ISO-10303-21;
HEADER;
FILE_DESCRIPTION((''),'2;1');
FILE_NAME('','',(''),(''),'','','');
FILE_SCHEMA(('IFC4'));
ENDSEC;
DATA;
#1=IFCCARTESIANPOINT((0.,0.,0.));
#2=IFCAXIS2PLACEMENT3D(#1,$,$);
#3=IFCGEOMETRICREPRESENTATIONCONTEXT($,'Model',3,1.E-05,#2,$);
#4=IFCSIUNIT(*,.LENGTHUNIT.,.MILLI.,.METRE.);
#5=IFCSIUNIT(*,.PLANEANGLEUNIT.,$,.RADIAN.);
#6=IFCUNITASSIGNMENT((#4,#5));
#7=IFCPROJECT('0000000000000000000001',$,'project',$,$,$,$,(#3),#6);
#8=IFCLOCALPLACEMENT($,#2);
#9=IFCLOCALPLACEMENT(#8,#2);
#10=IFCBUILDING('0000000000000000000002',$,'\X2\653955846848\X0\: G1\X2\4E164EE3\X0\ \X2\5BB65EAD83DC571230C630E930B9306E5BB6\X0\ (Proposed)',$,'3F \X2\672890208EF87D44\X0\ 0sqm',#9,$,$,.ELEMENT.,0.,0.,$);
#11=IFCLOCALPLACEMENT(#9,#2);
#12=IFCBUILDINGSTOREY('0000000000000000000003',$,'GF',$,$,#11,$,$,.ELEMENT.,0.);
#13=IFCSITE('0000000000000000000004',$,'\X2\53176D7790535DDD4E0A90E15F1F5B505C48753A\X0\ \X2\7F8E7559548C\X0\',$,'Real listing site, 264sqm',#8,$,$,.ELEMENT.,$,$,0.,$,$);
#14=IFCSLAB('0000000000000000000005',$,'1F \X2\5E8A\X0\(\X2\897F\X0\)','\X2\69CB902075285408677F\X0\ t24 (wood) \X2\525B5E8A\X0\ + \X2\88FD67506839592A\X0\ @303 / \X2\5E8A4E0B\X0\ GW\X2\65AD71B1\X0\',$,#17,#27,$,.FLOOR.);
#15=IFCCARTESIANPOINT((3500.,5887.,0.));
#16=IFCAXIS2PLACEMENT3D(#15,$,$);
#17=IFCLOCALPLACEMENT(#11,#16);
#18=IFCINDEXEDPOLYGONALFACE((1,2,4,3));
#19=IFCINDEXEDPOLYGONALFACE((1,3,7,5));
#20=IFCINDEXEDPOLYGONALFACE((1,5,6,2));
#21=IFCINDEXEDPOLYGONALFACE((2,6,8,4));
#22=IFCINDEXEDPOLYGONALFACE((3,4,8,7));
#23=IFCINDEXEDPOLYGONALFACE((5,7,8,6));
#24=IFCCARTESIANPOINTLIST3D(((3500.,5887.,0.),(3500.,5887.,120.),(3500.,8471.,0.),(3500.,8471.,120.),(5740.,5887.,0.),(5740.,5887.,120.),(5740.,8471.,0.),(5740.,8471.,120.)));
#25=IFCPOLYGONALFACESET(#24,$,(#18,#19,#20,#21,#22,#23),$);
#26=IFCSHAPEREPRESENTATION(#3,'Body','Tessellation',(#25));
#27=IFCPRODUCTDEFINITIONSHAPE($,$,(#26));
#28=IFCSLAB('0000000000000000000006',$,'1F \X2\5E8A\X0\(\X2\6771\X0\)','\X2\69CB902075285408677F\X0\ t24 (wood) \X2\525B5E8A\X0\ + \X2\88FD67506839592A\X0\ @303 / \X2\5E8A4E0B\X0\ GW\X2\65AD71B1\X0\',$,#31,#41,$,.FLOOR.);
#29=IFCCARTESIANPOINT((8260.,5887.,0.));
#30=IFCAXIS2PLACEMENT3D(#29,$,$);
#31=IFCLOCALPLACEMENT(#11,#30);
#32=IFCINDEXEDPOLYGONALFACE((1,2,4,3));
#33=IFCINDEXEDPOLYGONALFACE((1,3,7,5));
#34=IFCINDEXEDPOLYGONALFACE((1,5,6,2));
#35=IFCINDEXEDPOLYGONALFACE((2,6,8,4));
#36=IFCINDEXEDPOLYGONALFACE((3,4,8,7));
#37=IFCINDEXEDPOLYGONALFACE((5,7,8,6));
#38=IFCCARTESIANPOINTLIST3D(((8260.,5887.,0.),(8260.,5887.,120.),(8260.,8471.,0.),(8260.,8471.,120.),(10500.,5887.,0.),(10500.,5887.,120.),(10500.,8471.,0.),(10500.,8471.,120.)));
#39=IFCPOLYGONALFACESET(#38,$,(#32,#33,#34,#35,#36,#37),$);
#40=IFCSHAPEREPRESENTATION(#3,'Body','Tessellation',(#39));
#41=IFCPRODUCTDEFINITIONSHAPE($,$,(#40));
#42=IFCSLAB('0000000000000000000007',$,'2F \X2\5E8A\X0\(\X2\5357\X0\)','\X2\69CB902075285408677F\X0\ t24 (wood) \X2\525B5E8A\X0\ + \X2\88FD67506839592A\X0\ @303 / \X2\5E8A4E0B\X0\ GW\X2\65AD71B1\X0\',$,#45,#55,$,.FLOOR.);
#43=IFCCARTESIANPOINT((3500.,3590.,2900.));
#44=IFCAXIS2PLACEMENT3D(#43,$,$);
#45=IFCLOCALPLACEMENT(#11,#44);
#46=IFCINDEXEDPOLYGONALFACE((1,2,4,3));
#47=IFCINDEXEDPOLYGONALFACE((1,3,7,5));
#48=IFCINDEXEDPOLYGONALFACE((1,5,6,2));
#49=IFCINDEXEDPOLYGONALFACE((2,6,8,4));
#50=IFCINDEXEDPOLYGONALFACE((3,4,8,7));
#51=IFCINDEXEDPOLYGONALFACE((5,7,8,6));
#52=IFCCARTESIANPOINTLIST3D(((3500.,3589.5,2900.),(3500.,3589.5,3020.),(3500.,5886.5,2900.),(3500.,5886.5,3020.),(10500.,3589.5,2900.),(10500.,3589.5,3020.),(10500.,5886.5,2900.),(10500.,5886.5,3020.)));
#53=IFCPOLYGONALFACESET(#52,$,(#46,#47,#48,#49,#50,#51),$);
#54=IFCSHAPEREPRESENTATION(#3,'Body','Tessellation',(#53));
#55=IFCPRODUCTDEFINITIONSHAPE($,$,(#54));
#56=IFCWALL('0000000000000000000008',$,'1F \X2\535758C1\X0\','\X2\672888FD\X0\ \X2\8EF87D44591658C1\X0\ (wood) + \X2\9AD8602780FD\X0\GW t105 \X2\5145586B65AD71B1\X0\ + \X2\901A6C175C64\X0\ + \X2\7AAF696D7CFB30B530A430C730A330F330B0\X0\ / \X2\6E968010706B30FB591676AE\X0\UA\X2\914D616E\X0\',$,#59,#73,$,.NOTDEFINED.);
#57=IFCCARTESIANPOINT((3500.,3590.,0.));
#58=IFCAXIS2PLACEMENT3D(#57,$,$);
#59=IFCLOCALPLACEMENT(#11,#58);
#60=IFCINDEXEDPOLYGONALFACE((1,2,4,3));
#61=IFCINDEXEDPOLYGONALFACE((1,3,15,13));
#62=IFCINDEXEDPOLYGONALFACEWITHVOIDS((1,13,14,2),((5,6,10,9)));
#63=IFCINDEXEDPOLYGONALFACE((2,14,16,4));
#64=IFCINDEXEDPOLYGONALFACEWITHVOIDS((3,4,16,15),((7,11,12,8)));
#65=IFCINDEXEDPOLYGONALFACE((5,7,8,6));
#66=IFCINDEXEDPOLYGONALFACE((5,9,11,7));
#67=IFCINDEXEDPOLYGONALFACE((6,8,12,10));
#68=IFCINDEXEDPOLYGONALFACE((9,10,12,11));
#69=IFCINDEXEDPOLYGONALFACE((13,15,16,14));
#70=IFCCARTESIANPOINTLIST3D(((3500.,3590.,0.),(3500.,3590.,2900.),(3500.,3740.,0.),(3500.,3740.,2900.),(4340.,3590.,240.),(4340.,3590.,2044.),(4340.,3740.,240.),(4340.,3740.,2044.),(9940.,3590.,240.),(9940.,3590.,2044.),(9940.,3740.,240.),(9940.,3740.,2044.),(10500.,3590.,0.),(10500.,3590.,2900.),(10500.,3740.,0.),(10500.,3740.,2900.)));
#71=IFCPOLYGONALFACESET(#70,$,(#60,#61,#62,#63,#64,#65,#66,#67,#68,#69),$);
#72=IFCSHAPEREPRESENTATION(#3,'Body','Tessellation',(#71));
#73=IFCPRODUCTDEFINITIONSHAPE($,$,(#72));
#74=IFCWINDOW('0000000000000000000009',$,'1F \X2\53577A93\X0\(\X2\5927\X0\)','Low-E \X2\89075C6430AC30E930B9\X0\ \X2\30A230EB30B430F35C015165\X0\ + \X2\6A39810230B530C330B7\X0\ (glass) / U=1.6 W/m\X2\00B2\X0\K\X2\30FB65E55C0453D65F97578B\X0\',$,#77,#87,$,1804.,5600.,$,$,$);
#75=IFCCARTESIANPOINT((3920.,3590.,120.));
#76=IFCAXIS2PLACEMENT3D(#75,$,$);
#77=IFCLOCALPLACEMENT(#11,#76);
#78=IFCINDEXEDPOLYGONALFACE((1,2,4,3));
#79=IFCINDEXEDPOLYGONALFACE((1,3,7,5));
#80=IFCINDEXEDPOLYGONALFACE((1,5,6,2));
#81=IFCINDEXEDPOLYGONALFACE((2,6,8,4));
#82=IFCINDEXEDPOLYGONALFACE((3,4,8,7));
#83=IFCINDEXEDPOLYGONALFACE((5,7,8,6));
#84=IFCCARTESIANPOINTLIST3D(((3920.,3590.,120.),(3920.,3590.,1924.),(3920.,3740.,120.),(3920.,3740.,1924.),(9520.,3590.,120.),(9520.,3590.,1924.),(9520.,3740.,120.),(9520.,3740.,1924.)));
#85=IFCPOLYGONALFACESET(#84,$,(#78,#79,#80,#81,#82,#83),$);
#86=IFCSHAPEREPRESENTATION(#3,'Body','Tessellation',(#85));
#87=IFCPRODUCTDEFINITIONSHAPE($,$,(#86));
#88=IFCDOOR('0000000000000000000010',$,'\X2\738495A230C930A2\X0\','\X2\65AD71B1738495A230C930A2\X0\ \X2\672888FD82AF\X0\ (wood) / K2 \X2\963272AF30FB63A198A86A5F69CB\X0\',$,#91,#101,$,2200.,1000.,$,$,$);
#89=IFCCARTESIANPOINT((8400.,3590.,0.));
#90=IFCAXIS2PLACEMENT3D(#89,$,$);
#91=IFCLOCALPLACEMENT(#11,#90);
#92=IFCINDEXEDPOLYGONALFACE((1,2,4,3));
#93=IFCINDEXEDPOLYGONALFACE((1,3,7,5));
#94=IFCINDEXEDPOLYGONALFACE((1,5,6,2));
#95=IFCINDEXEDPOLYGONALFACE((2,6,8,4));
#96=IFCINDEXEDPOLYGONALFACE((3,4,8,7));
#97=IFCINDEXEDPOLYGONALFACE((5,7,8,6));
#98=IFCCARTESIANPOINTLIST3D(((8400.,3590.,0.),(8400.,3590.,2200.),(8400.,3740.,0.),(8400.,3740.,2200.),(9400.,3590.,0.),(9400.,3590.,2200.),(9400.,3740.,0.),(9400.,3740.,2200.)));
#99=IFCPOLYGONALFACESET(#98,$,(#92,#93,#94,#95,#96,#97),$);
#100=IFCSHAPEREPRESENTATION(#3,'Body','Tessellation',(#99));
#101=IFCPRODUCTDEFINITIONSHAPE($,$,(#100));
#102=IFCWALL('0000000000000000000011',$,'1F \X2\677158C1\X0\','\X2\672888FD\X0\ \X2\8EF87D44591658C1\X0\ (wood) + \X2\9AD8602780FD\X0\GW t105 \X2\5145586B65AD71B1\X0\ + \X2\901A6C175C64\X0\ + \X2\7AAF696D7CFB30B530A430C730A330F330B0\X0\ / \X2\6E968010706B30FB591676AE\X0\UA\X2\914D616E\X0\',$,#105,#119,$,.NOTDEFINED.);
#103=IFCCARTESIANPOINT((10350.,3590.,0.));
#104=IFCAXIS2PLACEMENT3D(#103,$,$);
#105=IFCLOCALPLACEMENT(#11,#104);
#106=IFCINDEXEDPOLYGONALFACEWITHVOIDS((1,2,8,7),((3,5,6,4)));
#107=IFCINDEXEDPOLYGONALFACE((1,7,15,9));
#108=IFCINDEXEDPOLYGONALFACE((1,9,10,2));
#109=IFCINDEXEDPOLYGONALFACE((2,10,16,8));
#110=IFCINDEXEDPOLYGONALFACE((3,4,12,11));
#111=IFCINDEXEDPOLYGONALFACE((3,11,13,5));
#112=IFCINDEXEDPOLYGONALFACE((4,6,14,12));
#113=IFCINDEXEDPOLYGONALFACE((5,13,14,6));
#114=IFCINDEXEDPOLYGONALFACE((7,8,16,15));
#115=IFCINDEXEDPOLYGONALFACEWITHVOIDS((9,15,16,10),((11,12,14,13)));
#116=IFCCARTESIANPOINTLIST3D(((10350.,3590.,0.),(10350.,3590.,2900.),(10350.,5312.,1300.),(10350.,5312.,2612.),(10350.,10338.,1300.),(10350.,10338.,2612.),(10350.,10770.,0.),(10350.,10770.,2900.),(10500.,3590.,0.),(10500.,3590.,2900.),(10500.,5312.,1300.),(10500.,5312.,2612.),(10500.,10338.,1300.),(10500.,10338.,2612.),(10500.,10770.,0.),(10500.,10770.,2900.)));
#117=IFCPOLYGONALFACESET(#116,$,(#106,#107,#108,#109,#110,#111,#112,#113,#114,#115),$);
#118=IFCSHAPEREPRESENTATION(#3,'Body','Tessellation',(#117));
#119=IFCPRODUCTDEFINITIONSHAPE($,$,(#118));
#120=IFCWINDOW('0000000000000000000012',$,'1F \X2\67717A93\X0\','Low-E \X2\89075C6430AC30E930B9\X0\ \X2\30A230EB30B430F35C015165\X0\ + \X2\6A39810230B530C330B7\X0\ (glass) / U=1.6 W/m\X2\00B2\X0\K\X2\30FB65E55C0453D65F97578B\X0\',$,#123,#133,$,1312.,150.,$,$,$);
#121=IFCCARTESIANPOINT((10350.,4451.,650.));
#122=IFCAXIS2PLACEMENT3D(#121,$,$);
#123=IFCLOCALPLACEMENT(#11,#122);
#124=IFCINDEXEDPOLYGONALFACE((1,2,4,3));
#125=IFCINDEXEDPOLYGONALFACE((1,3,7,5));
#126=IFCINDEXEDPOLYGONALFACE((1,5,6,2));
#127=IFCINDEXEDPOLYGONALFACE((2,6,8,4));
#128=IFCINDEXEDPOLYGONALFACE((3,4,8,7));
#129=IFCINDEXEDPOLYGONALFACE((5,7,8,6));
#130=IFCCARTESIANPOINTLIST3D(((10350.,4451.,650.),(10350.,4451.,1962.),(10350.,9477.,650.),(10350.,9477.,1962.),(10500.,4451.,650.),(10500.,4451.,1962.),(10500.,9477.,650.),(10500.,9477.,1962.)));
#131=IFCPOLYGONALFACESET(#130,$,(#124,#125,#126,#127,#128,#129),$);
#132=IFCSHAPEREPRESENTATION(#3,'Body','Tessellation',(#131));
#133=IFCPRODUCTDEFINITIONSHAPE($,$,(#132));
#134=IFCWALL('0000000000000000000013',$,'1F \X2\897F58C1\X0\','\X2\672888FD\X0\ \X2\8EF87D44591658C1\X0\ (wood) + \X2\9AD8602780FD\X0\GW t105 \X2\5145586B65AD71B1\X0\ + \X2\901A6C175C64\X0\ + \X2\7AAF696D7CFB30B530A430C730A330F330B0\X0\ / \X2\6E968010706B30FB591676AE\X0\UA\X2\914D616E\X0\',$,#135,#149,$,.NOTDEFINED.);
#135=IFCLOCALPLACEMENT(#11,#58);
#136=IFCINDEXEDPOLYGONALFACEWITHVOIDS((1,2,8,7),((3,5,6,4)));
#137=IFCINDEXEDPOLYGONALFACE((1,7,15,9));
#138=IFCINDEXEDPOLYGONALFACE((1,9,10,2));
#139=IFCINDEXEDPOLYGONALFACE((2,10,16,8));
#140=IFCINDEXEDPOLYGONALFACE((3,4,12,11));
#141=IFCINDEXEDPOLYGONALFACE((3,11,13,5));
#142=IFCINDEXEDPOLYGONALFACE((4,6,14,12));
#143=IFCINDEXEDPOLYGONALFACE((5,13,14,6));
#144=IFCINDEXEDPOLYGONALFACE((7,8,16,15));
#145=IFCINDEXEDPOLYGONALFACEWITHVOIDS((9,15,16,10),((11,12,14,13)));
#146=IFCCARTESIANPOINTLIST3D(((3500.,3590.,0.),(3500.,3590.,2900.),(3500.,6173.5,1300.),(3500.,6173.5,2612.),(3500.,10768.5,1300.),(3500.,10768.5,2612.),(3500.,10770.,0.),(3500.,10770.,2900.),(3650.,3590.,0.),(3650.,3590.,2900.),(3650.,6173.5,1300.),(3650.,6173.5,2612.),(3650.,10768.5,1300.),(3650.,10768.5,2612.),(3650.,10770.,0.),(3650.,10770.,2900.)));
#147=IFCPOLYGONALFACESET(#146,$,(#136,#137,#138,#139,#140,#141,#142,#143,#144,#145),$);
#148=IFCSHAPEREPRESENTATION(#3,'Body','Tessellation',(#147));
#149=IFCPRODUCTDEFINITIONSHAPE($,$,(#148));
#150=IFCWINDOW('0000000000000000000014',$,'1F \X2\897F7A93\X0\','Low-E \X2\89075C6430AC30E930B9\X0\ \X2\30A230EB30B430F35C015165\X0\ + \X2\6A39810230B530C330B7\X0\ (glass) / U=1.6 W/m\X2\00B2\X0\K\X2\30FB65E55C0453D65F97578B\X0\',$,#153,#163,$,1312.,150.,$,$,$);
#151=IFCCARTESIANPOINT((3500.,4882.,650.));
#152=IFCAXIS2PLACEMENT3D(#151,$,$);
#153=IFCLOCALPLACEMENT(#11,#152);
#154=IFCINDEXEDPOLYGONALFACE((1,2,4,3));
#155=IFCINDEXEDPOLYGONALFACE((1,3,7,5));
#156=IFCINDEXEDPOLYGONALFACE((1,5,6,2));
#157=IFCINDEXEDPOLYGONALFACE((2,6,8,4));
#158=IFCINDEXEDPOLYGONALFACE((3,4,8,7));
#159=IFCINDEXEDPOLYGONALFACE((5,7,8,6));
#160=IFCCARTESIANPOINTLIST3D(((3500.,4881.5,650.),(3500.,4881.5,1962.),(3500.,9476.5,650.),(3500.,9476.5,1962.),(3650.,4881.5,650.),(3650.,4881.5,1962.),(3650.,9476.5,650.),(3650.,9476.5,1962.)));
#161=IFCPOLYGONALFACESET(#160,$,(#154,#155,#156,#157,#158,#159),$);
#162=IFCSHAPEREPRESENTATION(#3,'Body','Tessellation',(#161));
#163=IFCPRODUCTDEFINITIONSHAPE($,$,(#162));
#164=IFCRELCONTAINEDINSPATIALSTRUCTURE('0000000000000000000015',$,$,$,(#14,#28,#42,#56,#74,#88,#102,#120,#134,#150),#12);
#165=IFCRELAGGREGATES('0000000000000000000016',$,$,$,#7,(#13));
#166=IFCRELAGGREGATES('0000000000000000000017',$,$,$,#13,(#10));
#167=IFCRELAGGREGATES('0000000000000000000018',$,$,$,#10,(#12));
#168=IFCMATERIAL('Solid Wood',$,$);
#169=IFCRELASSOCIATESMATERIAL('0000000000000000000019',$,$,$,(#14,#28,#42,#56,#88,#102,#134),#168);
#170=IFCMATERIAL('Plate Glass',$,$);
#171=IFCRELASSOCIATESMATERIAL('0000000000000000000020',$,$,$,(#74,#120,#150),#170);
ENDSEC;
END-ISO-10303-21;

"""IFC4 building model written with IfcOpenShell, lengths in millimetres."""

from ifc_helpers import new_model, si_unit, frame, frame_2d, origin, place, context, project, spatial, rectangle, extrude, material, element, fill, save


model = new_model("IFC4")

# Units and contexts
model_context = context("Model", 3, precision=1e-05, world=origin())
ifc_project = project(units=[si_unit("LENGTHUNIT", "METRE", prefix="MILLI"), si_unit("PLANEANGLEUNIT", "RADIAN")], contexts=[model_context])

# Site, building, storey
site_placement = place(None, origin())
site = spatial("IfcSite", under=ifc_project, at=site_placement, Name="北海道川上郡弟子屈町 美留和", ObjectType="Real listing site, 264sqm", CompositionType="ELEMENT", RefElevation=0.0)
building_placement = place(site_placement, origin())
building = spatial("IfcBuilding", under=site, at=building_placement, Name="改善案: G1世代 家庭菜園テラスの家 (Proposed)", ObjectType="3F 木造軸組 0sqm", CompositionType="ELEMENT", ElevationOfRefHeight=0.0, ElevationOfTerrain=0.0)
storey_placement = place(building_placement, origin())
storey = spatial("IfcBuildingStorey", under=building, at=storey_placement, Name="GF", CompositionType="ELEMENT", Elevation=0.0)

# Slabs
ifc_material_1 = material(Name="Solid Wood")
slab_1_placement = place(storey_placement, frame((3500.0, 5887.0, 0.0)))
element("IfcSlab", 1, at=slab_1_placement, inside=storey, material=ifc_material_1, Name="1F 床(西)", Description="構造用合板 t24 (wood) 剛床 + 製材根太 @303 / 床下 GW断熱", PredefinedType="FLOOR", context=model_context, shape_type="SweptSolid", body=[
    extrude(rectangle(XDim=2240.0, YDim=2584.0, at=frame_2d((1120.0, 1292.0))), frame((3500.0, 5887.0, 0.0)), (0.0, 0.0, 1.0), 120.0),
])
slab_2_placement = place(storey_placement, frame((8260.0, 5887.0, 0.0)))
element("IfcSlab", 2, at=slab_2_placement, inside=storey, material=ifc_material_1, Name="1F 床(東)", Description="構造用合板 t24 (wood) 剛床 + 製材根太 @303 / 床下 GW断熱", PredefinedType="FLOOR", context=model_context, shape_type="SweptSolid", body=[
    extrude(rectangle(XDim=2240.0, YDim=2584.0, at=frame_2d((1120.0, 1292.0))), frame((8260.0, 5887.0, 0.0)), (0.0, 0.0, 1.0), 120.0),
])
slab_3_placement = place(storey_placement, frame((3500.0, 3590.0, 2900.0)))
element("IfcSlab", 3, at=slab_3_placement, inside=storey, material=ifc_material_1, Name="2F 床(南)", Description="構造用合板 t24 (wood) 剛床 + 製材根太 @303 / 床下 GW断熱", PredefinedType="FLOOR", context=model_context, shape_type="SweptSolid", body=[
    extrude(rectangle(XDim=7000.0, YDim=2297.0, at=frame_2d((3500.0, 1148.0))), frame((3500.0, 3590.0, 2900.0)), (0.0, 0.0, 1.0), 120.0),
])

# Wall, openings, window, door
wall_1_placement = place(storey_placement, frame((3500.0, 3590.0, 0.0)))
wall_1 = element("IfcWall", 4, at=wall_1_placement, inside=storey, material=ifc_material_1, Name="1F 南壁", Description="木製 軸組外壁 (wood) + 高性能GW t105 充填断熱 + 通気層 + 窯業系サイディング / 準耐火・外皮UA配慮", PredefinedType="NOTDEFINED", context=model_context, shape_type="SweptSolid", body=[
    extrude(rectangle(XDim=7000.0, YDim=150.0, at=frame_2d((3500.0, 75.0))), frame((3500.0, 3590.0, 0.0)), (0.0, 0.0, 1.0), 2900.0),
])
opening_1_placement = place(storey_placement, frame((3920.0, 3590.0, 120.0)))
opening_1 = element("IfcOpeningElement", 5, at=opening_1_placement, cuts=wall_1, PredefinedType="NOTDEFINED", context=model_context, shape_type="SweptSolid", body=[
    extrude(rectangle(XDim=5600.0, YDim=150.0, at=frame_2d((2800.0, 75.0))), frame((3920.0, 3590.0, 120.0)), (0.0, 0.0, 1.0), 1804.0),
])
opening_2_placement = place(storey_placement, frame((8400.0, 3590.0, 0.0)))
opening_2 = element("IfcOpeningElement", 6, at=opening_2_placement, cuts=wall_1, PredefinedType="NOTDEFINED", context=model_context, shape_type="SweptSolid", body=[
    extrude(rectangle(XDim=1000.0, YDim=150.0, at=frame_2d((500.0, 75.0))), frame((8400.0, 3590.0, 0.0)), (0.0, 0.0, 1.0), 2200.0),
])
ifc_material_2 = material(Name="Plate Glass")
window_1_placement = place(storey_placement, frame((3920.0, 3590.0, 120.0)))
window_1 = element("IfcWindow", 7, at=window_1_placement, inside=storey, material=ifc_material_2, Name="1F 南窓(大)", Description="Low-E 複層ガラス アルゴン封入 + 樹脂サッシ (glass) / U=1.6 W/m²K・日射取得型", OverallHeight=1804.0, OverallWidth=5600.0, context=model_context, shape_type="SweptSolid", body=[
    extrude(rectangle(XDim=5600.0, YDim=150.0, at=frame_2d((2800.0, 75.0))), frame((3920.0, 3590.0, 120.0)), (0.0, 0.0, 1.0), 1804.0),
])
fill(opening_1, window_1)
door_placement = place(storey_placement, frame((8400.0, 3590.0, 0.0)))
door = element("IfcDoor", 8, at=door_placement, inside=storey, material=ifc_material_1, Name="玄関ドア", Description="断熱玄関ドア 木製芯 (wood) / K2 防犯・採風機構", OverallHeight=2200.0, OverallWidth=1000.0, context=model_context, shape_type="SweptSolid", body=[
    extrude(rectangle(XDim=1000.0, YDim=150.0, at=frame_2d((500.0, 75.0))), frame((8400.0, 3590.0, 0.0)), (0.0, 0.0, 1.0), 2200.0),
])
fill(opening_2, door)

# Walls, openings, windows
wall_2_placement = place(storey_placement, frame((10350.0, 3590.0, 0.0)))
wall_2 = element("IfcWall", 9, at=wall_2_placement, inside=storey, material=ifc_material_1, Name="1F 東壁", Description="木製 軸組外壁 (wood) + 高性能GW t105 充填断熱 + 通気層 + 窯業系サイディング / 準耐火・外皮UA配慮", PredefinedType="NOTDEFINED", context=model_context, shape_type="SweptSolid", body=[
    extrude(rectangle(XDim=150.0, YDim=7180.0, at=frame_2d((75.0, 3590.0))), frame((10350.0, 3590.0, 0.0)), (0.0, 0.0, 1.0), 2900.0),
])
opening_3_placement = place(storey_placement, frame((10350.0, 4451.0, 650.0)))
opening_3 = element("IfcOpeningElement", 10, at=opening_3_placement, cuts=wall_2, PredefinedType="NOTDEFINED", context=model_context, shape_type="SweptSolid", body=[
    extrude(rectangle(XDim=150.0, YDim=5026.0, at=frame_2d((75.0, 2513.0))), frame((10350.0, 4451.0, 650.0)), (0.0, 0.0, 1.0), 1312.0),
])
window_2_placement = place(storey_placement, frame((10350.0, 4451.0, 650.0)))
window_2 = element("IfcWindow", 11, at=window_2_placement, inside=storey, material=ifc_material_2, Name="1F 東窓", Description="Low-E 複層ガラス アルゴン封入 + 樹脂サッシ (glass) / U=1.6 W/m²K・日射取得型", OverallHeight=1312.0, OverallWidth=150.0, context=model_context, shape_type="SweptSolid", body=[
    extrude(rectangle(XDim=150.0, YDim=5026.0, at=frame_2d((75.0, 2513.0))), frame((10350.0, 4451.0, 650.0)), (0.0, 0.0, 1.0), 1312.0),
])
fill(opening_3, window_2)
wall_3_placement = place(storey_placement, frame((3500.0, 3590.0, 0.0)))
wall_3 = element("IfcWall", 12, at=wall_3_placement, inside=storey, material=ifc_material_1, Name="1F 西壁", Description="木製 軸組外壁 (wood) + 高性能GW t105 充填断熱 + 通気層 + 窯業系サイディング / 準耐火・外皮UA配慮", PredefinedType="NOTDEFINED", context=model_context, shape_type="SweptSolid", body=[
    extrude(rectangle(XDim=150.0, YDim=7180.0, at=frame_2d((75.0, 3590.0))), frame((3500.0, 3590.0, 0.0)), (0.0, 0.0, 1.0), 2900.0),
])
opening_4_placement = place(storey_placement, frame((3500.0, 4882.0, 650.0)))
opening_4 = element("IfcOpeningElement", 13, at=opening_4_placement, cuts=wall_3, PredefinedType="NOTDEFINED", context=model_context, shape_type="SweptSolid", body=[
    extrude(rectangle(XDim=150.0, YDim=4595.0, at=frame_2d((75.0, 2297.0))), frame((3500.0, 4882.0, 650.0)), (0.0, 0.0, 1.0), 1312.0),
])
window_3_placement = place(storey_placement, frame((3500.0, 4882.0, 650.0)))
window_3 = element("IfcWindow", 14, at=window_3_placement, inside=storey, material=ifc_material_2, Name="1F 西窓", Description="Low-E 複層ガラス アルゴン封入 + 樹脂サッシ (glass) / U=1.6 W/m²K・日射取得型", OverallHeight=1312.0, OverallWidth=150.0, context=model_context, shape_type="SweptSolid", body=[
    extrude(rectangle(XDim=150.0, YDim=4595.0, at=frame_2d((75.0, 2297.0))), frame((3500.0, 4882.0, 650.0)), (0.0, 0.0, 1.0), 1312.0),
])
fill(opening_4, window_3)

save(model, "model.ifc")
